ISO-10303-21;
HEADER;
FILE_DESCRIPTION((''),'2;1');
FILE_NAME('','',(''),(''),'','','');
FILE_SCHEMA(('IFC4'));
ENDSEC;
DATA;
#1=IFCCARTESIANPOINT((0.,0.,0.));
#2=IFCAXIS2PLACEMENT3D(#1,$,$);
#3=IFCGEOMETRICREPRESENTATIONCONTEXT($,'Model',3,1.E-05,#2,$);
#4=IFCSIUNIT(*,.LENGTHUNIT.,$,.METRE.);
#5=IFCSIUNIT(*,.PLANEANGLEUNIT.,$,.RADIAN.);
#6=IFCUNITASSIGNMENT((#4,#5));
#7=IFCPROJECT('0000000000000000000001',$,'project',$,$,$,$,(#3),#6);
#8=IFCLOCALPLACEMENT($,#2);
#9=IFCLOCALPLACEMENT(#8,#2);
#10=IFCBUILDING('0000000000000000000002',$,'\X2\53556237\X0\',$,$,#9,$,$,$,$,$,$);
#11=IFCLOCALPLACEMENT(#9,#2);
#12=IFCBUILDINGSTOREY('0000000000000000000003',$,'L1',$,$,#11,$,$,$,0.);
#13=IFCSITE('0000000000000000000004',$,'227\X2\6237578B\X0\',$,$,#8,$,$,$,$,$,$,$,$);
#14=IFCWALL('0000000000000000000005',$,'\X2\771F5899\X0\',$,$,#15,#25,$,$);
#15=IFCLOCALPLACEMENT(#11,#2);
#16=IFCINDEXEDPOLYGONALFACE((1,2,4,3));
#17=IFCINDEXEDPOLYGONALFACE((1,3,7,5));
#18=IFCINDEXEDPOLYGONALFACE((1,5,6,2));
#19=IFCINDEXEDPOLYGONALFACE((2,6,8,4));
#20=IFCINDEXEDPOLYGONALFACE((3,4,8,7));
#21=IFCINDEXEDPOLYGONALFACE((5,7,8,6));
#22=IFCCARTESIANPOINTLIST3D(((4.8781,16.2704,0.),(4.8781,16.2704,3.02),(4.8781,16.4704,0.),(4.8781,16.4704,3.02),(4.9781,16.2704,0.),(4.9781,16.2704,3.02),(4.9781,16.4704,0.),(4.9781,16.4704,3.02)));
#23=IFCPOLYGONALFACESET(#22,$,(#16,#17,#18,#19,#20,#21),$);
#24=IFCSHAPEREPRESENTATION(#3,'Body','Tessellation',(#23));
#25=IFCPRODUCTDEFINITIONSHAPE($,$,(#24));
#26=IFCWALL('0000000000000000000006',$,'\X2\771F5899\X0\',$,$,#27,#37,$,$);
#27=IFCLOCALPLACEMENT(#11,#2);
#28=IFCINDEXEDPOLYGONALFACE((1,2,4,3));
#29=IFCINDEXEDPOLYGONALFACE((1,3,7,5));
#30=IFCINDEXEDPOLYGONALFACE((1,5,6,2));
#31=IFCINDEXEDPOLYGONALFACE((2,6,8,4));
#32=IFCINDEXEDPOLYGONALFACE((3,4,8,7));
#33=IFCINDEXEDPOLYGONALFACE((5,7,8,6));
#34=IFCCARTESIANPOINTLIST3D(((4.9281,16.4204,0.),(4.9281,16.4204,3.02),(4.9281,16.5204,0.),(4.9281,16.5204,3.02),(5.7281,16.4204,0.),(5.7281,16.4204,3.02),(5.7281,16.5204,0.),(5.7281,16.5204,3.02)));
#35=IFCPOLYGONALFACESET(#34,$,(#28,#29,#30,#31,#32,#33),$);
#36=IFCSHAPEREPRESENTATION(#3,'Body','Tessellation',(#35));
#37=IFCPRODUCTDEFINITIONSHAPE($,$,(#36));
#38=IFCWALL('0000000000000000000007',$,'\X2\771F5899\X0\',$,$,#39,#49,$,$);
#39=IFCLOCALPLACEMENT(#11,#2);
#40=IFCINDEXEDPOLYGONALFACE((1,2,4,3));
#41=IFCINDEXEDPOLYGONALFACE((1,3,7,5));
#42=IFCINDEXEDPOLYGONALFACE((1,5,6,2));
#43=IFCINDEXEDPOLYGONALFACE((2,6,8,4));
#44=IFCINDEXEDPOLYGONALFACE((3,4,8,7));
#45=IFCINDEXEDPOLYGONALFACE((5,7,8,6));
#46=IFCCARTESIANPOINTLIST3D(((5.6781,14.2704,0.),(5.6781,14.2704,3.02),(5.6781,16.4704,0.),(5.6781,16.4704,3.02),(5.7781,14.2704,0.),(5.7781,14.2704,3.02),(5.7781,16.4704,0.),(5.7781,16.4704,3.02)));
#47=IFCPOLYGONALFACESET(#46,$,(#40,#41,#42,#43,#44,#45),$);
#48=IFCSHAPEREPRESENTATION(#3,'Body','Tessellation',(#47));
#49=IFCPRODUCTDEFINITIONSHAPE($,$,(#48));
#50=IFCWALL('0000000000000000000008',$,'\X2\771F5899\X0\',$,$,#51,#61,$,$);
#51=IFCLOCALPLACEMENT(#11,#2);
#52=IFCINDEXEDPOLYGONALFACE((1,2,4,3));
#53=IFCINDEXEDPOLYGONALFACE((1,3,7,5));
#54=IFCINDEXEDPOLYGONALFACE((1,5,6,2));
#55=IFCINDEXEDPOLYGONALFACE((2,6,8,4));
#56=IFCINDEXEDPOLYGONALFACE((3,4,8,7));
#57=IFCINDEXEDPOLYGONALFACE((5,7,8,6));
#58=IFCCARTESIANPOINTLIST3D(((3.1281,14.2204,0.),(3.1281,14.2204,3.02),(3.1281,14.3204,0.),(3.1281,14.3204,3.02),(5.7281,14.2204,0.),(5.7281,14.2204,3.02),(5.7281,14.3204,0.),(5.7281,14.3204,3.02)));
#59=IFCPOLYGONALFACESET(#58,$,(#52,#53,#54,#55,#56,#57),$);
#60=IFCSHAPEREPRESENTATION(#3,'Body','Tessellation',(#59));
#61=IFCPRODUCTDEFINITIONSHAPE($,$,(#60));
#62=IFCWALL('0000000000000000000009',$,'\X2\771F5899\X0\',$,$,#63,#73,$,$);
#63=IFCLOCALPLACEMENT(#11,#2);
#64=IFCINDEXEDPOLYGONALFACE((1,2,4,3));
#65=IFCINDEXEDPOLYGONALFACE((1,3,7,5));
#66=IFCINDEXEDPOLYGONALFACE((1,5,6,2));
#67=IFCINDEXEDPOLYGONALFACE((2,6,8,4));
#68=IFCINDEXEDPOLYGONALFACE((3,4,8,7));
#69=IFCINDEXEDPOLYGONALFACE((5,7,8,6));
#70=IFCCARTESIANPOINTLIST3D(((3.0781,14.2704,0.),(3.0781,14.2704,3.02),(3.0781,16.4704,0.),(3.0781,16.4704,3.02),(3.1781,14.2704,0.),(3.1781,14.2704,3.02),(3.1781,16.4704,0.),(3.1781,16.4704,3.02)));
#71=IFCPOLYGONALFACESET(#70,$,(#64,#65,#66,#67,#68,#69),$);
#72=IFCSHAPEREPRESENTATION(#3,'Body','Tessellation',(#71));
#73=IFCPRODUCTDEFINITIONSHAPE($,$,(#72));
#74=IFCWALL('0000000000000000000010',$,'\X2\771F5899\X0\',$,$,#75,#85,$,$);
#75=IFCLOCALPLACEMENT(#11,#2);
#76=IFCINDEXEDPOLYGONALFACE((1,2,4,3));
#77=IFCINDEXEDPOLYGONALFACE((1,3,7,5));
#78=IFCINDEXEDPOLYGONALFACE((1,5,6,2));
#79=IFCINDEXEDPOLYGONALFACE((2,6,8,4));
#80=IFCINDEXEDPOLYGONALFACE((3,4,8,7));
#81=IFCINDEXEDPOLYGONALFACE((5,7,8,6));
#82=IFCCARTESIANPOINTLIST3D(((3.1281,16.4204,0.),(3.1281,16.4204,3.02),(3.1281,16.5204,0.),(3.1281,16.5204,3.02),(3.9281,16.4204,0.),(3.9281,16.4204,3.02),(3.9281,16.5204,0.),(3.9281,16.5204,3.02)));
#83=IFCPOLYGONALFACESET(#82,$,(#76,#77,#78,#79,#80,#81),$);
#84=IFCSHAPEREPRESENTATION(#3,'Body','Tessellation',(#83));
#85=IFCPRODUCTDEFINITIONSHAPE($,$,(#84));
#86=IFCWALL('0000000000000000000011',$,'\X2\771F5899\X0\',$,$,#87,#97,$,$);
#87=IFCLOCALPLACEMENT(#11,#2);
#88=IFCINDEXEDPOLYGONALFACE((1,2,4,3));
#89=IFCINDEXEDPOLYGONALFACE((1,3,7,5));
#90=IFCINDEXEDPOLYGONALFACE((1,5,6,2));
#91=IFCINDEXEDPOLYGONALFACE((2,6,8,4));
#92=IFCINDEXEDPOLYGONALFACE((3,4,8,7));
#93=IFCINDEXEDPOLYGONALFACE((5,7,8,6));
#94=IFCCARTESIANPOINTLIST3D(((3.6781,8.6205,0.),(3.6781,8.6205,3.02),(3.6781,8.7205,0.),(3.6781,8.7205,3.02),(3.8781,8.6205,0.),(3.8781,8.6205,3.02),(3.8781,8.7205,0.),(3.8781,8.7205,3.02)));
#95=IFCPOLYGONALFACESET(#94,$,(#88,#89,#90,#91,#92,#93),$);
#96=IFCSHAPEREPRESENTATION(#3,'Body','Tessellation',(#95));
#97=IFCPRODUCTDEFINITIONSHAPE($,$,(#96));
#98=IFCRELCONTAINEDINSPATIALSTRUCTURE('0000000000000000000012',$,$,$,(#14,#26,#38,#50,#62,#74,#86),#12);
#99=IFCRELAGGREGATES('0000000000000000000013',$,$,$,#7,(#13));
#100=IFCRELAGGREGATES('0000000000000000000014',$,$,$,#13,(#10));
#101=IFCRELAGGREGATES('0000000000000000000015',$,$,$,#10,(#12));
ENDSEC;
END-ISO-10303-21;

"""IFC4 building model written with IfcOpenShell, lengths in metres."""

from ifc_helpers import new_model, si_unit, origin, place, context, project, spatial, polyline, outline, extrude, element, save


model = new_model("IFC4")

# Units and contexts
model_context = context("Model", 3, precision=1e-05, world=origin())
ifc_project = project(units=[si_unit("LENGTHUNIT", "METRE"), si_unit("PLANEANGLEUNIT", "RADIAN")], contexts=[model_context])

# Site, building, storey
site_placement = place(None, origin())
site = spatial("IfcSite", under=ifc_project, at=site_placement, Name="227户型")
building_placement = place(site_placement, origin())
building = spatial("IfcBuilding", under=site, at=building_placement, Name="单户")
storey_placement = place(building_placement, origin())
storey = spatial("IfcBuildingStorey", under=building, at=storey_placement, Name="L1", Elevation=0.0)

# Walls
wall_1_placement = place(storey_placement, origin())
element("IfcWall", 1, at=wall_1_placement, inside=storey, Name="真墙", context=model_context, shape_type="SweptSolid", body=[
    extrude(outline(polyline([(4.8781, 16.2704), (4.8781, 16.4704), (4.9781, 16.4704), (4.9781, 16.2704), (4.8781, 16.2704)])), origin(), (0.0, 0.0, 1.0), 3.02),
])
wall_2_placement = place(storey_placement, origin())
element("IfcWall", 2, at=wall_2_placement, inside=storey, Name="真墙", context=model_context, shape_type="SweptSolid", body=[
    extrude(outline(polyline([(4.9281, 16.5204), (5.7281, 16.5204), (5.7281, 16.4204), (4.9281, 16.4204), (4.9281, 16.5204)])), origin(), (0.0, 0.0, 1.0), 3.02),
])
wall_3_placement = place(storey_placement, origin())
element("IfcWall", 3, at=wall_3_placement, inside=storey, Name="真墙", context=model_context, shape_type="SweptSolid", body=[
    extrude(outline(polyline([(5.7781, 16.4704), (5.7781, 14.2704), (5.6781, 14.2704), (5.6781, 16.4704), (5.7781, 16.4704)])), origin(), (0.0, 0.0, 1.0), 3.02),
])
wall_4_placement = place(storey_placement, origin())
element("IfcWall", 4, at=wall_4_placement, inside=storey, Name="真墙", context=model_context, shape_type="SweptSolid", body=[
    extrude(outline(polyline([(5.7281, 14.2204), (3.1281, 14.2204), (3.1281, 14.3204), (5.7281, 14.3204), (5.7281, 14.2204)])), origin(), (0.0, 0.0, 1.0), 3.02),
])
wall_5_placement = place(storey_placement, origin())
element("IfcWall", 5, at=wall_5_placement, inside=storey, Name="真墙", context=model_context, shape_type="SweptSolid", body=[
    extrude(outline(polyline([(3.0781, 14.2704), (3.0781, 16.4704), (3.1781, 16.4704), (3.1781, 14.2704), (3.0781, 14.2704)])), origin(), (0.0, 0.0, 1.0), 3.02),
])
wall_6_placement = place(storey_placement, origin())
element("IfcWall", 6, at=wall_6_placement, inside=storey, Name="真墙", context=model_context, shape_type="SweptSolid", body=[
    extrude(outline(polyline([(3.1281, 16.5204), (3.9281, 16.5204), (3.9281, 16.4204), (3.1281, 16.4204), (3.1281, 16.5204)])), origin(), (0.0, 0.0, 1.0), 3.02),
])
wall_7_placement = place(storey_placement, origin())
element("IfcWall", 7, at=wall_7_placement, inside=storey, Name="真墙", context=model_context, shape_type="SweptSolid", body=[
    extrude(outline(polyline([(3.6781, 8.7205), (3.8781, 8.7205), (3.8781, 8.6205), (3.6781, 8.6205), (3.6781, 8.7205)])), origin(), (0.0, 0.0, 1.0), 3.02),
])

save(model, "model.ifc")
